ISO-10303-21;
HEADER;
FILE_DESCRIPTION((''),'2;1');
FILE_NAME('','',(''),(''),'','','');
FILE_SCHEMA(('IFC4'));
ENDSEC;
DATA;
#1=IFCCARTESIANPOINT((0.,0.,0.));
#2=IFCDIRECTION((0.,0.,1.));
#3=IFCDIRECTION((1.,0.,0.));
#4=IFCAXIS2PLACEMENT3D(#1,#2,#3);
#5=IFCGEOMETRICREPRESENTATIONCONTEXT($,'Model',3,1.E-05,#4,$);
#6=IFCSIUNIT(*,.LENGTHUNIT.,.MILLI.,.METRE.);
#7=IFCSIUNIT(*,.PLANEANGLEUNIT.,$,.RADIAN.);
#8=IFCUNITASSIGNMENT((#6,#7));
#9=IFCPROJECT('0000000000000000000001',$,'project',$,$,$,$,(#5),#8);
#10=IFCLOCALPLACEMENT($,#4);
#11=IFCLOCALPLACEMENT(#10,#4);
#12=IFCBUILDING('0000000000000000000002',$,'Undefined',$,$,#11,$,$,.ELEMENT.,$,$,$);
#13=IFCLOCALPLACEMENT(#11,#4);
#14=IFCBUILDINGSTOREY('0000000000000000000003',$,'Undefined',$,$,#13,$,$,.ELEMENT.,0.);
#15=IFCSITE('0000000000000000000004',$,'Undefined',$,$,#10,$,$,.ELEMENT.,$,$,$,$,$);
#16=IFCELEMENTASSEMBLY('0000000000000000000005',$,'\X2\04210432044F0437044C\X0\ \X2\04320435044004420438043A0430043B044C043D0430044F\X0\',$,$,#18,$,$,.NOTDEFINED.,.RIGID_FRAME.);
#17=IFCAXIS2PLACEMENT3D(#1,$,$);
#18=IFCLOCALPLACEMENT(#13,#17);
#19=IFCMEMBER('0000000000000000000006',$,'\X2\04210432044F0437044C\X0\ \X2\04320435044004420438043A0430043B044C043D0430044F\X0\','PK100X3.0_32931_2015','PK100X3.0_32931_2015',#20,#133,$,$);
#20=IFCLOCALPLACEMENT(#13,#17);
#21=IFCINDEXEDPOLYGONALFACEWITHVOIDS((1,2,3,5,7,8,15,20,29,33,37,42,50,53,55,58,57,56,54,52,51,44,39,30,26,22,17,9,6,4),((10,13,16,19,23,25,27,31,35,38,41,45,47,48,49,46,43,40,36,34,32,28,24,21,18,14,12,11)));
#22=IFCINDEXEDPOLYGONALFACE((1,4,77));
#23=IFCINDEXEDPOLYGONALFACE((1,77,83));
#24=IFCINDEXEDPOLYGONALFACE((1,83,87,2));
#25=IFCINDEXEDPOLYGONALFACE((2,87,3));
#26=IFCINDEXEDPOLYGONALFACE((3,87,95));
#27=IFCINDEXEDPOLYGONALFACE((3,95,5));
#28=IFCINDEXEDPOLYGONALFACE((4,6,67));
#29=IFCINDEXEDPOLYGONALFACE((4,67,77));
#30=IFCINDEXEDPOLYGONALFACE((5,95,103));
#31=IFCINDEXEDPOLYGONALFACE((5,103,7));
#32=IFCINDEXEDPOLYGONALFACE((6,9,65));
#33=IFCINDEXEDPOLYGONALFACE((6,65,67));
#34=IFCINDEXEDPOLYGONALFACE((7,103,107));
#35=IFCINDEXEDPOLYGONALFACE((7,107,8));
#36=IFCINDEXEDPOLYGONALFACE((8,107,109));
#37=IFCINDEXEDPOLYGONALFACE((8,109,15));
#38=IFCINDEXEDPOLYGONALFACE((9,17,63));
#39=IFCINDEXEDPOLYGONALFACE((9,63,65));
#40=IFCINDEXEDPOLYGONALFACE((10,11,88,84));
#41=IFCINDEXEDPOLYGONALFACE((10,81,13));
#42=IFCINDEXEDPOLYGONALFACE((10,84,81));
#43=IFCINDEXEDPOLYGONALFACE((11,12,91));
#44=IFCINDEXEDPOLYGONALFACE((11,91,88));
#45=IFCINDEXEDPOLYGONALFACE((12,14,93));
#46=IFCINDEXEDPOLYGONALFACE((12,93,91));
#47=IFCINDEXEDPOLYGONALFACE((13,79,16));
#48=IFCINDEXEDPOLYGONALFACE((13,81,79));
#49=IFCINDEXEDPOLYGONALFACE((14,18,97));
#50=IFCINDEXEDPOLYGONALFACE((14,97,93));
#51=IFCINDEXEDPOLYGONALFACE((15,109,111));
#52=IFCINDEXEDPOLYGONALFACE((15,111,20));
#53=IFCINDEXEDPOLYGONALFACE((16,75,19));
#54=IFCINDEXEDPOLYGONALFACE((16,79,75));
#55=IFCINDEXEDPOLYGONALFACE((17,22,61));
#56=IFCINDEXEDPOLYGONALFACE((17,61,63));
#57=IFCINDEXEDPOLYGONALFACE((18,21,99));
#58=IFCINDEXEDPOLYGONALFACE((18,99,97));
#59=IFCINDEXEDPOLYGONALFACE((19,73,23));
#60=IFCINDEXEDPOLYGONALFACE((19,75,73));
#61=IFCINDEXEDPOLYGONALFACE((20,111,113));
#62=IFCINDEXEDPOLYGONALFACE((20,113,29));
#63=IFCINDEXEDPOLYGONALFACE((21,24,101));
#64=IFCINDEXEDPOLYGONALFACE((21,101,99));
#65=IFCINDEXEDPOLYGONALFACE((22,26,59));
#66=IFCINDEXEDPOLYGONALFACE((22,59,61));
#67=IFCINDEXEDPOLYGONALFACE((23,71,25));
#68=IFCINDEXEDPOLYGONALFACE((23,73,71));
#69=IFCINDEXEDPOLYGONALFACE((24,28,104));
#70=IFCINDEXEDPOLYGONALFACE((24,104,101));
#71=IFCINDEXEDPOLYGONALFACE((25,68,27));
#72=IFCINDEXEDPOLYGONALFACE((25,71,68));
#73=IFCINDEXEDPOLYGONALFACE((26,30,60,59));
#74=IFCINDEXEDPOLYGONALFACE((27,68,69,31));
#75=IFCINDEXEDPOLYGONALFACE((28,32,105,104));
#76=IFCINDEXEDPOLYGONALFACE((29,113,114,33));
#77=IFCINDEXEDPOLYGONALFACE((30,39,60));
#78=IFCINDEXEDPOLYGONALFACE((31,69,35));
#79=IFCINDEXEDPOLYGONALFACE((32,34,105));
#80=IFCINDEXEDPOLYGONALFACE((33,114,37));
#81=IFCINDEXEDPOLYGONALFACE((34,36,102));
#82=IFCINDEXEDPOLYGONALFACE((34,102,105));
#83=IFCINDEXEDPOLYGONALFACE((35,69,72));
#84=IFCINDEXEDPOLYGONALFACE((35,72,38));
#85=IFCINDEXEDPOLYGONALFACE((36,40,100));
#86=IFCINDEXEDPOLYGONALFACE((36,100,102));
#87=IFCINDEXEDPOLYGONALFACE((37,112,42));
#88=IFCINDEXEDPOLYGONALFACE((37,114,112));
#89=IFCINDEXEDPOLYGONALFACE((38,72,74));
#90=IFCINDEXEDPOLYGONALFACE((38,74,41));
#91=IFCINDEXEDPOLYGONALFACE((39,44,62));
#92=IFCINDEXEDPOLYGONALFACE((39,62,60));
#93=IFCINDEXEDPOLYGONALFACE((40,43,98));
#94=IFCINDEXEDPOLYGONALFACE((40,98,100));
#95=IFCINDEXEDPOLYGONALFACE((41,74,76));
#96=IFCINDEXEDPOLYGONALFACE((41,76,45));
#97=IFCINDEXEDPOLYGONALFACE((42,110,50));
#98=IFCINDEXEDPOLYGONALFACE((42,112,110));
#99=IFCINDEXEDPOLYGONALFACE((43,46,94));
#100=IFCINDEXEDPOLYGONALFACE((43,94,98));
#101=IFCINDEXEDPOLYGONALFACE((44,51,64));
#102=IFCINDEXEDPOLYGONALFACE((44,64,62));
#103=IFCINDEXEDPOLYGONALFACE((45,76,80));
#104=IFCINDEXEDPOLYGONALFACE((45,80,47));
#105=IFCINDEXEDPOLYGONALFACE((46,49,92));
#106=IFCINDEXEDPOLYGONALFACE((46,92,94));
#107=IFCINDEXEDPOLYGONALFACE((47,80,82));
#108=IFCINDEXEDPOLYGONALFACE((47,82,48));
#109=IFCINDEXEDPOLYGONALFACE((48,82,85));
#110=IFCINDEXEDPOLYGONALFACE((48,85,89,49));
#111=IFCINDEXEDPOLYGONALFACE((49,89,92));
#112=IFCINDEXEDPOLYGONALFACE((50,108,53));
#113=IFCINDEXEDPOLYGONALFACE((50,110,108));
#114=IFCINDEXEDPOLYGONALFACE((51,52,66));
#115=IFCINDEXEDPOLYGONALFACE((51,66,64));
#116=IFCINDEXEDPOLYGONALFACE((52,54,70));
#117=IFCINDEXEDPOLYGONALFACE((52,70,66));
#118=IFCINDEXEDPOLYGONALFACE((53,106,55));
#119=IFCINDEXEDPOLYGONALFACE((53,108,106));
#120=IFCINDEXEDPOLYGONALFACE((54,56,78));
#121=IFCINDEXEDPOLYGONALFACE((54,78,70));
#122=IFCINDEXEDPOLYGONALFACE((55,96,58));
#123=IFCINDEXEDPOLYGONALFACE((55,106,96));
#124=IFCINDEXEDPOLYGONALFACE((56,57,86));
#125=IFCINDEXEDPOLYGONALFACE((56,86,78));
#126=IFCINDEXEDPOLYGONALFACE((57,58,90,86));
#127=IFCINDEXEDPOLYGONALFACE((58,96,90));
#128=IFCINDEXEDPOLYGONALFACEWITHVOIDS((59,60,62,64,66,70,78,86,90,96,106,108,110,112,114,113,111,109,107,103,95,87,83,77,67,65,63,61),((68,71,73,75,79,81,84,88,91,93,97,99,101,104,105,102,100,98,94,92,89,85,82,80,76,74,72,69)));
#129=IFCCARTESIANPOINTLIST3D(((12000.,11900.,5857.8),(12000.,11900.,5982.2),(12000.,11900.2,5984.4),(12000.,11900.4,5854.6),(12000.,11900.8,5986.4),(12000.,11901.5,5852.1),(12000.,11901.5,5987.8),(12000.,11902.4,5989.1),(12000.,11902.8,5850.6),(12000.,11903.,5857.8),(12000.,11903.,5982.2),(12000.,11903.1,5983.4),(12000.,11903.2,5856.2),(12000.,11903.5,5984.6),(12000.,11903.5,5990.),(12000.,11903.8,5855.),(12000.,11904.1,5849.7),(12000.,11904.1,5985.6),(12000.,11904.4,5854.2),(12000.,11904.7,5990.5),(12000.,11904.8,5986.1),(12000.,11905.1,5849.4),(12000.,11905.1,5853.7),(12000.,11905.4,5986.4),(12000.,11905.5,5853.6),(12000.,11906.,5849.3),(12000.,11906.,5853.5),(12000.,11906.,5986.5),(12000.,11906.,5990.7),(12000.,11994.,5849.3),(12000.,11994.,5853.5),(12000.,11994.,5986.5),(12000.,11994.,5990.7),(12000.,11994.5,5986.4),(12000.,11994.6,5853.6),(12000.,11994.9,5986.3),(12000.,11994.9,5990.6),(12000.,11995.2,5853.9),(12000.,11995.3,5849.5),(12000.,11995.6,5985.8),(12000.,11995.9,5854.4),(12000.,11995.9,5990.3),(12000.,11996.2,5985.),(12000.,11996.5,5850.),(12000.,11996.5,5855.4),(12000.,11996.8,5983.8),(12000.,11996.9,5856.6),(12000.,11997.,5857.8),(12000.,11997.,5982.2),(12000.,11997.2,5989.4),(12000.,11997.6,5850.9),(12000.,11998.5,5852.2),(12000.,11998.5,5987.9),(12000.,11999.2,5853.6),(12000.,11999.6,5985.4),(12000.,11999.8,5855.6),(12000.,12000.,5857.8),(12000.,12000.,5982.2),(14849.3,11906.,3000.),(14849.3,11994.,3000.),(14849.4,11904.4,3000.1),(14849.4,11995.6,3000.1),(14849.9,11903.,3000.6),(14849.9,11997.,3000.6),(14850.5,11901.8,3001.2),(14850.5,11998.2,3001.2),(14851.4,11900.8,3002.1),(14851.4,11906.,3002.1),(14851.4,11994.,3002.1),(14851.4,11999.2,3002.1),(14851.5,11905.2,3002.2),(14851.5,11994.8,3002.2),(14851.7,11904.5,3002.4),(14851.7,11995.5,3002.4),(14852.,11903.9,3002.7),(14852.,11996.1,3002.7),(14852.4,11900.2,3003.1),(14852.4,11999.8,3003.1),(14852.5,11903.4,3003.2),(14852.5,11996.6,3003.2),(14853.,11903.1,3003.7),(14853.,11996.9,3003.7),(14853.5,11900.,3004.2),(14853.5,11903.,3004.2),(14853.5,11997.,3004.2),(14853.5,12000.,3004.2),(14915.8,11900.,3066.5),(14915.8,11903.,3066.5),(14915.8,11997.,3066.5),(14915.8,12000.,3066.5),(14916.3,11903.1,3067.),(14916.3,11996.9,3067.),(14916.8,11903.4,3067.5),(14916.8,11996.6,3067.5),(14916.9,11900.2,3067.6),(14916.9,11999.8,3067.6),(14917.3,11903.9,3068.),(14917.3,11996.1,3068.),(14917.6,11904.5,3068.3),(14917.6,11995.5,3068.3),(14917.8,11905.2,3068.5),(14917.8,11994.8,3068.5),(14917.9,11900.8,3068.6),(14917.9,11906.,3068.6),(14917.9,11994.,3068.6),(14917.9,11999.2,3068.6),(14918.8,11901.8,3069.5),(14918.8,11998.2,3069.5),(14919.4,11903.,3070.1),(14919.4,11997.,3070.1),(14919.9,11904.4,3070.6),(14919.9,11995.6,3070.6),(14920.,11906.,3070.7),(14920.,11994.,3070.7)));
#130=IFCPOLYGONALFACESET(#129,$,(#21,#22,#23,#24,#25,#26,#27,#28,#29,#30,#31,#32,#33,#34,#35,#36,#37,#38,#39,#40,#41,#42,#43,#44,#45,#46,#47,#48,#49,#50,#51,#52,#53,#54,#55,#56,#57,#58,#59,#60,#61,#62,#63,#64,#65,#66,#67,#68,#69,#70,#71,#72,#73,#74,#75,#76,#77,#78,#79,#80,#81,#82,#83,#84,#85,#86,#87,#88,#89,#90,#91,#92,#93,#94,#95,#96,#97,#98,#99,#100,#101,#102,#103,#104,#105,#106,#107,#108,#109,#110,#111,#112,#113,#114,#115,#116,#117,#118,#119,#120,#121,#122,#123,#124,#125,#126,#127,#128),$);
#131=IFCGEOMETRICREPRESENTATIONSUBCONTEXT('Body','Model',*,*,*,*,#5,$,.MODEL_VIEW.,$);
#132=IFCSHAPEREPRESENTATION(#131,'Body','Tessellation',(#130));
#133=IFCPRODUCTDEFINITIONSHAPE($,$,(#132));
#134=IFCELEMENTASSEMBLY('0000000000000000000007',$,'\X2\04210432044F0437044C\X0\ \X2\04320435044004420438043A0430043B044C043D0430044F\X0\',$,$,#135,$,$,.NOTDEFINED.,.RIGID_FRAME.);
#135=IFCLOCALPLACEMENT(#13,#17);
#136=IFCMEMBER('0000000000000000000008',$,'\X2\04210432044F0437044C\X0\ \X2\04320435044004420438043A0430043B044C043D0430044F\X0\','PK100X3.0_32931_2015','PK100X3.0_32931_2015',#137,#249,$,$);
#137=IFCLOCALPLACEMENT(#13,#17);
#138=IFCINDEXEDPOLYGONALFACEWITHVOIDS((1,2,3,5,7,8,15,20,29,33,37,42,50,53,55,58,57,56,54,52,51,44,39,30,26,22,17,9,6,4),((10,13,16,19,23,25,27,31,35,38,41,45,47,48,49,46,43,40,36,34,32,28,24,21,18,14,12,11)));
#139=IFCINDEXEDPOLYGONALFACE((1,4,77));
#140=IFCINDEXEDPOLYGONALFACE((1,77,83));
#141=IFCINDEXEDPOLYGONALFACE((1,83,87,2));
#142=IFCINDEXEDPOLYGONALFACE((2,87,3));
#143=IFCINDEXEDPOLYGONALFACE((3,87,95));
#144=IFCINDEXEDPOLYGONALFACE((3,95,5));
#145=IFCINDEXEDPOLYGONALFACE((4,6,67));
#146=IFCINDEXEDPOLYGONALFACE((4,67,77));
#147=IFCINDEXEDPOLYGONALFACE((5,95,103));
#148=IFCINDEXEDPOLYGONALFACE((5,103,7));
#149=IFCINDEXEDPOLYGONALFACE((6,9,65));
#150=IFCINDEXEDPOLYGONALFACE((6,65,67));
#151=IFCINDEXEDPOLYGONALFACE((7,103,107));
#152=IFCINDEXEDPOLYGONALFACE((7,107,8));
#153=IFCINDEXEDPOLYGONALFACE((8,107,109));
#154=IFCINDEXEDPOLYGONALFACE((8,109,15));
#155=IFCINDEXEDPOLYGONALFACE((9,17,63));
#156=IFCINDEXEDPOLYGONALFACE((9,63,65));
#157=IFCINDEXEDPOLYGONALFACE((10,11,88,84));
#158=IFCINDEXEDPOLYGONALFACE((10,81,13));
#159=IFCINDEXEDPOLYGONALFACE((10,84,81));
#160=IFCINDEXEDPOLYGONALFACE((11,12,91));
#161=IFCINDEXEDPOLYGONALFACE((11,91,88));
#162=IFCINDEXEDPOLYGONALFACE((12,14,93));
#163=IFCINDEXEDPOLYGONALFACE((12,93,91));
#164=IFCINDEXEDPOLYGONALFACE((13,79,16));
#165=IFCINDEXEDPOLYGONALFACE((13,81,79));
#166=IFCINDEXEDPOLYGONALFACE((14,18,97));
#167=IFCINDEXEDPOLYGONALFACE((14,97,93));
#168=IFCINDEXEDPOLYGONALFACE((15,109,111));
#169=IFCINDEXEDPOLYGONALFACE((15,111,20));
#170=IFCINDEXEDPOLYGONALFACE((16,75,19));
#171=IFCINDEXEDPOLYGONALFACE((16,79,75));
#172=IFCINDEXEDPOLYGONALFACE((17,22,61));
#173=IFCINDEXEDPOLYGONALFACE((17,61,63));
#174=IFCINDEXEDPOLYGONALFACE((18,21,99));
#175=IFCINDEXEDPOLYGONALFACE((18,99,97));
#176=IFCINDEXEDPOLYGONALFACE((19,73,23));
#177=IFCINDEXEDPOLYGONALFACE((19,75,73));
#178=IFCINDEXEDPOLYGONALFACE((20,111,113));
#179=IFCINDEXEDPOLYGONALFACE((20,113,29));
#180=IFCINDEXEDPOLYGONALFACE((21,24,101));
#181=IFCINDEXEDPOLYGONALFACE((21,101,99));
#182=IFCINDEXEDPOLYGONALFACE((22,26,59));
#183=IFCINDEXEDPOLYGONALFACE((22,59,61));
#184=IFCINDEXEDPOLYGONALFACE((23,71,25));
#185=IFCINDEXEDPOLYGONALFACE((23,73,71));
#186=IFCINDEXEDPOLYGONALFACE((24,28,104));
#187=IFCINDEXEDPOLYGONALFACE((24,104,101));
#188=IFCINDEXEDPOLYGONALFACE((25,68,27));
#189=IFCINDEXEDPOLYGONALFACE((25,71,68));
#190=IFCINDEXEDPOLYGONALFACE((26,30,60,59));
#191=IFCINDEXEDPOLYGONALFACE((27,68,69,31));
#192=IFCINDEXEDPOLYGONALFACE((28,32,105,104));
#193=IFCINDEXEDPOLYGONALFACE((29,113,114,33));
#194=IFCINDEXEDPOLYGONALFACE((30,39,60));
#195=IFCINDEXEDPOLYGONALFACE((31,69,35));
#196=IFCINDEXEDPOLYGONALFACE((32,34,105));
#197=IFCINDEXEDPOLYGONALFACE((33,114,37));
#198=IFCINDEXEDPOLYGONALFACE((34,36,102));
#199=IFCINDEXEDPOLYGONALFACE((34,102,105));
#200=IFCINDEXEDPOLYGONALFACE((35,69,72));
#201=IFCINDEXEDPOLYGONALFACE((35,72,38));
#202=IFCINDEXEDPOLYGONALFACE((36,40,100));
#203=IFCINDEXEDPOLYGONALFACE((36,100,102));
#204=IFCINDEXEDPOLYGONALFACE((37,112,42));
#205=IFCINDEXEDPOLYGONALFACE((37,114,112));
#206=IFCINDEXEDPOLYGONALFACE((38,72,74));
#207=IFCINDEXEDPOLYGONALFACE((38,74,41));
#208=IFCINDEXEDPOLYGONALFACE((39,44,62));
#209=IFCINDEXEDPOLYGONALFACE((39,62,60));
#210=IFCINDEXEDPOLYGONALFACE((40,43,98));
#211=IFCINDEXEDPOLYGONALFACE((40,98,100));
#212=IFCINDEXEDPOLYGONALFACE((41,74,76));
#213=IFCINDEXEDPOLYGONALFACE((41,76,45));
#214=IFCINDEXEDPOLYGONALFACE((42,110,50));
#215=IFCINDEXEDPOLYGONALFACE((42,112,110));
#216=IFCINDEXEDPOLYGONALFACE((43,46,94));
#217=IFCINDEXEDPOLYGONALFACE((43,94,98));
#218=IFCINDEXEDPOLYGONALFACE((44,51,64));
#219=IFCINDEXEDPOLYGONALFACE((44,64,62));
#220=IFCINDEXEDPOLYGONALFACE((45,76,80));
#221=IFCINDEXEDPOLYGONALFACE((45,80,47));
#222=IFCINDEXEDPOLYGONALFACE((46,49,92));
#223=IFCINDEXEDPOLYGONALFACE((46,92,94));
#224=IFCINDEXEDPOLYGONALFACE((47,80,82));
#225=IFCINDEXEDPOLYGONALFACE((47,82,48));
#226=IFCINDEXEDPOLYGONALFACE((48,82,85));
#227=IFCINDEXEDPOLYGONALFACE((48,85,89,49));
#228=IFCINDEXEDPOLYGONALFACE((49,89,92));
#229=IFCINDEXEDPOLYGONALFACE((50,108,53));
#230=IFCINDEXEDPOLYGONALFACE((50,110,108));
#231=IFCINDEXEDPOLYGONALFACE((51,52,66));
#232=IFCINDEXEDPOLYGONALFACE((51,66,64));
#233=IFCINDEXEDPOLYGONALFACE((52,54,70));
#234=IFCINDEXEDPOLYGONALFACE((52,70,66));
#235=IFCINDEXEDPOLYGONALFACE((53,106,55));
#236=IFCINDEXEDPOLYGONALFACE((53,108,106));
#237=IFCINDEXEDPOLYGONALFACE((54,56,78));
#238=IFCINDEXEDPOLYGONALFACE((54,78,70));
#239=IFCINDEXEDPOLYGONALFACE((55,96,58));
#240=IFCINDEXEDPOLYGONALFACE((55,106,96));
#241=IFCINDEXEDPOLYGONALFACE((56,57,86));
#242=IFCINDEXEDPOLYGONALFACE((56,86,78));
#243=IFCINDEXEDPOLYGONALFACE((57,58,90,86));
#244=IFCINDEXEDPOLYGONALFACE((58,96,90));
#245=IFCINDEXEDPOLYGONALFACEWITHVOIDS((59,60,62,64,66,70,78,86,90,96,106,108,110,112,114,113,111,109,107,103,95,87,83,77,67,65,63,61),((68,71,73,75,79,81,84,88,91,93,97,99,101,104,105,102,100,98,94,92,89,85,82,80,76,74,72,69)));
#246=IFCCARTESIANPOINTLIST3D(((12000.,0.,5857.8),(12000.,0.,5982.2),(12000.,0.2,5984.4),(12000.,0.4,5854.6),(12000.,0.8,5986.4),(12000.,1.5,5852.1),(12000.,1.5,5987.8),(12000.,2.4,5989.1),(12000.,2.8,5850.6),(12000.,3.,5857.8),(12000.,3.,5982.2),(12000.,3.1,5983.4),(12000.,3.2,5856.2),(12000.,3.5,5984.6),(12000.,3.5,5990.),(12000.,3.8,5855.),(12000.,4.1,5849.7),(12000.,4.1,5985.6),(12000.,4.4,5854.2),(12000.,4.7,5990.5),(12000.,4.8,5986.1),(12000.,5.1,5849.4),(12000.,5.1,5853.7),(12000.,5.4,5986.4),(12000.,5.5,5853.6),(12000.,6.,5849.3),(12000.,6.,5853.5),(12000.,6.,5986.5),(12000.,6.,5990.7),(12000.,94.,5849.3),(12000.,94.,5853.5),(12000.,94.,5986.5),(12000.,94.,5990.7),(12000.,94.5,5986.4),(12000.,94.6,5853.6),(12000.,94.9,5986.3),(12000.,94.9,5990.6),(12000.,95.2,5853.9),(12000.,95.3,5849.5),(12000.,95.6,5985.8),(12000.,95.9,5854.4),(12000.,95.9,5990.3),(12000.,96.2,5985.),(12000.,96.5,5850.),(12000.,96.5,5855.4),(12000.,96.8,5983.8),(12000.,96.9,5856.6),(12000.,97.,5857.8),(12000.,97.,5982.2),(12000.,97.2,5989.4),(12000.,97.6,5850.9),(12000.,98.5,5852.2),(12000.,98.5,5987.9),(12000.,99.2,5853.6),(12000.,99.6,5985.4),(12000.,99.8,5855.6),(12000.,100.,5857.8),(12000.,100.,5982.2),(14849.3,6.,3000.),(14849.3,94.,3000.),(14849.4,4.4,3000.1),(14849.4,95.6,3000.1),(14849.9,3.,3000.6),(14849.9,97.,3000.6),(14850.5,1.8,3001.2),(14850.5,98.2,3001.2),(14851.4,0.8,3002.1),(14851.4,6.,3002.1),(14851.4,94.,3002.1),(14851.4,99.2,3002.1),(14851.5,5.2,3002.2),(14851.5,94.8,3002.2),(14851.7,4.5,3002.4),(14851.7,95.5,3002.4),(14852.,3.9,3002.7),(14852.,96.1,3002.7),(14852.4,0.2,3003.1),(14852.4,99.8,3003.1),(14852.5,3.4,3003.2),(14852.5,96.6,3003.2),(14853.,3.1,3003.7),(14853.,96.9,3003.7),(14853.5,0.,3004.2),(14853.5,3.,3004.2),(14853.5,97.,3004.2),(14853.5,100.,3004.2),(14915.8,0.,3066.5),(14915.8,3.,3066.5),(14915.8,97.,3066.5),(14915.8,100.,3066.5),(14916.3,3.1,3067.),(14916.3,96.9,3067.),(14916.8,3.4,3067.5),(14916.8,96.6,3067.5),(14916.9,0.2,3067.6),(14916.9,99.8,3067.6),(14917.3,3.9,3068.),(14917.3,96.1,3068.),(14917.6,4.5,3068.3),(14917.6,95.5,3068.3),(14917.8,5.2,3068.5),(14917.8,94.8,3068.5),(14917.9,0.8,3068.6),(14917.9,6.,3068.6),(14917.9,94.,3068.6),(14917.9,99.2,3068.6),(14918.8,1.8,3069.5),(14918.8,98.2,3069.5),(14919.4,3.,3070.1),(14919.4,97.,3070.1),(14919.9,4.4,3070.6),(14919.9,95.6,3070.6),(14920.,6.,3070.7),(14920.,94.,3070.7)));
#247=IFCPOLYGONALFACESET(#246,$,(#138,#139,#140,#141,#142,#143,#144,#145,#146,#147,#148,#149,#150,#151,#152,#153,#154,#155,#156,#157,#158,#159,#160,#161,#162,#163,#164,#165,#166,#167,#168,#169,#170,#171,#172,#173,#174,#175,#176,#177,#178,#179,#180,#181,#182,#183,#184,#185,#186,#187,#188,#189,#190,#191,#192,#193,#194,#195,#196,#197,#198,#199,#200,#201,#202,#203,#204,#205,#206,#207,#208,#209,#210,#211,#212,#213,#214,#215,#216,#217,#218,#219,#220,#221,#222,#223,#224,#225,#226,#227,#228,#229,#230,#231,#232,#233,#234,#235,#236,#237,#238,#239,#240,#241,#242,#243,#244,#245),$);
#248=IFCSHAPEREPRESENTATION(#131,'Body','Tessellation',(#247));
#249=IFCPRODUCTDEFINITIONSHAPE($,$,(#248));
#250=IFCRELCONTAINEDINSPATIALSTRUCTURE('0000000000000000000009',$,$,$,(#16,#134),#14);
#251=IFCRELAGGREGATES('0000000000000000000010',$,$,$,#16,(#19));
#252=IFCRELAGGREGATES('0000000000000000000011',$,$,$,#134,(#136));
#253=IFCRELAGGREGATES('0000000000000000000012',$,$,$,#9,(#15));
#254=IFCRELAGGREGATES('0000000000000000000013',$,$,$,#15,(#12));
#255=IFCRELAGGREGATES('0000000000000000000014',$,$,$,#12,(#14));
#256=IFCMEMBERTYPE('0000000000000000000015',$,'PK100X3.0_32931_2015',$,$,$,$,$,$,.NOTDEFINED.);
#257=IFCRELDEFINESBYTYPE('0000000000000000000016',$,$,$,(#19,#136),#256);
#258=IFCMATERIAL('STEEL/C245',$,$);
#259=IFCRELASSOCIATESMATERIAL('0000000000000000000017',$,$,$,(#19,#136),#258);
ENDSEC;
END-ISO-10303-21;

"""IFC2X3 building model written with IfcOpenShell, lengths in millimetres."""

from ifc_helpers import new_model, si_unit, frame, origin_with_axes, origin_2d_with_axis, place, context, subcontext, project, spatial, hollow_rectangle, extrude, clip, halfspace, material, type_object, element, aggregate, save


model = new_model("IFC2X3")

# Units and contexts
model_context = context("Model", 3, precision=1e-05, world=origin_with_axes())
body_context = subcontext(model_context, "Body", "Model", "MODEL_VIEW")
ifc_project = project(units=[si_unit("LENGTHUNIT", "METRE", prefix="MILLI"), si_unit("PLANEANGLEUNIT", "RADIAN")], contexts=[model_context])

# Site, building, storey
site_placement = place(None, origin_with_axes())
site = spatial("IfcSite", under=ifc_project, at=site_placement, Name="Undefined", CompositionType="ELEMENT")
building_placement = place(site_placement, origin_with_axes())
building = spatial("IfcBuilding", under=site, at=building_placement, Name="Undefined", CompositionType="ELEMENT")
storey_placement = place(building_placement, origin_with_axes())
storey = spatial("IfcBuildingStorey", under=building, at=storey_placement, Name="Undefined", CompositionType="ELEMENT", Elevation=0.0)

# Shared definitions
ifc_material = material(Name="STEEL/C245")

# Element assemblies, members
assembly_1_placement = place(storey_placement, origin_with_axes())
assembly_1 = element("IfcElementAssembly", 1, at=assembly_1_placement, inside=storey, Name="Связь вертикальная", AssemblyPlace="NOTDEFINED", PredefinedType="RIGID_FRAME")
member_type_1 = type_object("IfcMemberType", Name="PK100X3.0_32931_2015", PredefinedType="NOTDEFINED")
member_1_placement = place(assembly_1_placement, frame((14920.0, 11950.0, 3000.0), z_axis=(0.707107, 0.0, 0.707107), x_axis=(-0.707107, 0.0, 0.707107)))
member_1 = element("IfcMember", 2, at=member_1_placement, type_object=member_type_1, material=ifc_material, Name="Связь вертикальная", Description="PK100X3.0_32931_2015", ObjectType="PK100X3.0_32931_2015", context=body_context, shape_type="Clipping", body=[
    clip(clip(extrude(hollow_rectangle(XDim=100.0, YDim=100.0, WallThickness=3.0, InnerFilletRadius=3.0, OuterFilletRadius=6.0, at=origin_2d_with_axis()), frame((4230.5, 0.0, 0.0), z_axis=(-1.0, 0.0, 0.0), x_axis=(0.0, -1.0, 0.0)), (0.0, 0.0, 1.0), 4281.5), halfspace(frame((3995.7, -50.0, -133.8), z_axis=(-0.707107, 0.0, 0.707107), x_axis=(0.0, -1.0, 0.0)), True)), halfspace(frame((50.0, -50.0, -176.9), z_axis=(-1.0, 0.0, 0.0), x_axis=(0.0, 0.0, 1.0)), False)),
])
aggregate(assembly_1, [member_1])
assembly_2_placement = place(storey_placement, origin_with_axes())
assembly_2 = element("IfcElementAssembly", 3, at=assembly_2_placement, inside=storey, Name="Связь вертикальная", AssemblyPlace="NOTDEFINED", PredefinedType="RIGID_FRAME")
member_2_placement = place(assembly_2_placement, frame((14920.0, 50.0, 3000.0), z_axis=(0.707107, 0.0, 0.707107), x_axis=(-0.707107, 0.0, 0.707107)))
member_2 = element("IfcMember", 4, at=member_2_placement, type_object=member_type_1, material=ifc_material, Name="Связь вертикальная", Description="PK100X3.0_32931_2015", ObjectType="PK100X3.0_32931_2015", context=body_context, shape_type="Clipping", body=[
    clip(clip(extrude(hollow_rectangle(XDim=100.0, YDim=100.0, WallThickness=3.0, InnerFilletRadius=3.0, OuterFilletRadius=6.0, at=origin_2d_with_axis()), frame((4230.5, 0.0, 0.0), z_axis=(-1.0, 0.0, 0.0), x_axis=(0.0, -1.0, 0.0)), (0.0, 0.0, 1.0), 4281.5), halfspace(frame((3995.7, 50.0, -133.8), z_axis=(-0.707107, 0.0, 0.707107), x_axis=(-0.707107, 0.0, -0.707107)), True)), halfspace(frame((50.0, 50.0, -176.9), z_axis=(-1.0, 0.0, 0.0), x_axis=(0.0, 1.0, 0.0)), False)),
])
aggregate(assembly_2, [member_2])

save(model, "model.ifc")
